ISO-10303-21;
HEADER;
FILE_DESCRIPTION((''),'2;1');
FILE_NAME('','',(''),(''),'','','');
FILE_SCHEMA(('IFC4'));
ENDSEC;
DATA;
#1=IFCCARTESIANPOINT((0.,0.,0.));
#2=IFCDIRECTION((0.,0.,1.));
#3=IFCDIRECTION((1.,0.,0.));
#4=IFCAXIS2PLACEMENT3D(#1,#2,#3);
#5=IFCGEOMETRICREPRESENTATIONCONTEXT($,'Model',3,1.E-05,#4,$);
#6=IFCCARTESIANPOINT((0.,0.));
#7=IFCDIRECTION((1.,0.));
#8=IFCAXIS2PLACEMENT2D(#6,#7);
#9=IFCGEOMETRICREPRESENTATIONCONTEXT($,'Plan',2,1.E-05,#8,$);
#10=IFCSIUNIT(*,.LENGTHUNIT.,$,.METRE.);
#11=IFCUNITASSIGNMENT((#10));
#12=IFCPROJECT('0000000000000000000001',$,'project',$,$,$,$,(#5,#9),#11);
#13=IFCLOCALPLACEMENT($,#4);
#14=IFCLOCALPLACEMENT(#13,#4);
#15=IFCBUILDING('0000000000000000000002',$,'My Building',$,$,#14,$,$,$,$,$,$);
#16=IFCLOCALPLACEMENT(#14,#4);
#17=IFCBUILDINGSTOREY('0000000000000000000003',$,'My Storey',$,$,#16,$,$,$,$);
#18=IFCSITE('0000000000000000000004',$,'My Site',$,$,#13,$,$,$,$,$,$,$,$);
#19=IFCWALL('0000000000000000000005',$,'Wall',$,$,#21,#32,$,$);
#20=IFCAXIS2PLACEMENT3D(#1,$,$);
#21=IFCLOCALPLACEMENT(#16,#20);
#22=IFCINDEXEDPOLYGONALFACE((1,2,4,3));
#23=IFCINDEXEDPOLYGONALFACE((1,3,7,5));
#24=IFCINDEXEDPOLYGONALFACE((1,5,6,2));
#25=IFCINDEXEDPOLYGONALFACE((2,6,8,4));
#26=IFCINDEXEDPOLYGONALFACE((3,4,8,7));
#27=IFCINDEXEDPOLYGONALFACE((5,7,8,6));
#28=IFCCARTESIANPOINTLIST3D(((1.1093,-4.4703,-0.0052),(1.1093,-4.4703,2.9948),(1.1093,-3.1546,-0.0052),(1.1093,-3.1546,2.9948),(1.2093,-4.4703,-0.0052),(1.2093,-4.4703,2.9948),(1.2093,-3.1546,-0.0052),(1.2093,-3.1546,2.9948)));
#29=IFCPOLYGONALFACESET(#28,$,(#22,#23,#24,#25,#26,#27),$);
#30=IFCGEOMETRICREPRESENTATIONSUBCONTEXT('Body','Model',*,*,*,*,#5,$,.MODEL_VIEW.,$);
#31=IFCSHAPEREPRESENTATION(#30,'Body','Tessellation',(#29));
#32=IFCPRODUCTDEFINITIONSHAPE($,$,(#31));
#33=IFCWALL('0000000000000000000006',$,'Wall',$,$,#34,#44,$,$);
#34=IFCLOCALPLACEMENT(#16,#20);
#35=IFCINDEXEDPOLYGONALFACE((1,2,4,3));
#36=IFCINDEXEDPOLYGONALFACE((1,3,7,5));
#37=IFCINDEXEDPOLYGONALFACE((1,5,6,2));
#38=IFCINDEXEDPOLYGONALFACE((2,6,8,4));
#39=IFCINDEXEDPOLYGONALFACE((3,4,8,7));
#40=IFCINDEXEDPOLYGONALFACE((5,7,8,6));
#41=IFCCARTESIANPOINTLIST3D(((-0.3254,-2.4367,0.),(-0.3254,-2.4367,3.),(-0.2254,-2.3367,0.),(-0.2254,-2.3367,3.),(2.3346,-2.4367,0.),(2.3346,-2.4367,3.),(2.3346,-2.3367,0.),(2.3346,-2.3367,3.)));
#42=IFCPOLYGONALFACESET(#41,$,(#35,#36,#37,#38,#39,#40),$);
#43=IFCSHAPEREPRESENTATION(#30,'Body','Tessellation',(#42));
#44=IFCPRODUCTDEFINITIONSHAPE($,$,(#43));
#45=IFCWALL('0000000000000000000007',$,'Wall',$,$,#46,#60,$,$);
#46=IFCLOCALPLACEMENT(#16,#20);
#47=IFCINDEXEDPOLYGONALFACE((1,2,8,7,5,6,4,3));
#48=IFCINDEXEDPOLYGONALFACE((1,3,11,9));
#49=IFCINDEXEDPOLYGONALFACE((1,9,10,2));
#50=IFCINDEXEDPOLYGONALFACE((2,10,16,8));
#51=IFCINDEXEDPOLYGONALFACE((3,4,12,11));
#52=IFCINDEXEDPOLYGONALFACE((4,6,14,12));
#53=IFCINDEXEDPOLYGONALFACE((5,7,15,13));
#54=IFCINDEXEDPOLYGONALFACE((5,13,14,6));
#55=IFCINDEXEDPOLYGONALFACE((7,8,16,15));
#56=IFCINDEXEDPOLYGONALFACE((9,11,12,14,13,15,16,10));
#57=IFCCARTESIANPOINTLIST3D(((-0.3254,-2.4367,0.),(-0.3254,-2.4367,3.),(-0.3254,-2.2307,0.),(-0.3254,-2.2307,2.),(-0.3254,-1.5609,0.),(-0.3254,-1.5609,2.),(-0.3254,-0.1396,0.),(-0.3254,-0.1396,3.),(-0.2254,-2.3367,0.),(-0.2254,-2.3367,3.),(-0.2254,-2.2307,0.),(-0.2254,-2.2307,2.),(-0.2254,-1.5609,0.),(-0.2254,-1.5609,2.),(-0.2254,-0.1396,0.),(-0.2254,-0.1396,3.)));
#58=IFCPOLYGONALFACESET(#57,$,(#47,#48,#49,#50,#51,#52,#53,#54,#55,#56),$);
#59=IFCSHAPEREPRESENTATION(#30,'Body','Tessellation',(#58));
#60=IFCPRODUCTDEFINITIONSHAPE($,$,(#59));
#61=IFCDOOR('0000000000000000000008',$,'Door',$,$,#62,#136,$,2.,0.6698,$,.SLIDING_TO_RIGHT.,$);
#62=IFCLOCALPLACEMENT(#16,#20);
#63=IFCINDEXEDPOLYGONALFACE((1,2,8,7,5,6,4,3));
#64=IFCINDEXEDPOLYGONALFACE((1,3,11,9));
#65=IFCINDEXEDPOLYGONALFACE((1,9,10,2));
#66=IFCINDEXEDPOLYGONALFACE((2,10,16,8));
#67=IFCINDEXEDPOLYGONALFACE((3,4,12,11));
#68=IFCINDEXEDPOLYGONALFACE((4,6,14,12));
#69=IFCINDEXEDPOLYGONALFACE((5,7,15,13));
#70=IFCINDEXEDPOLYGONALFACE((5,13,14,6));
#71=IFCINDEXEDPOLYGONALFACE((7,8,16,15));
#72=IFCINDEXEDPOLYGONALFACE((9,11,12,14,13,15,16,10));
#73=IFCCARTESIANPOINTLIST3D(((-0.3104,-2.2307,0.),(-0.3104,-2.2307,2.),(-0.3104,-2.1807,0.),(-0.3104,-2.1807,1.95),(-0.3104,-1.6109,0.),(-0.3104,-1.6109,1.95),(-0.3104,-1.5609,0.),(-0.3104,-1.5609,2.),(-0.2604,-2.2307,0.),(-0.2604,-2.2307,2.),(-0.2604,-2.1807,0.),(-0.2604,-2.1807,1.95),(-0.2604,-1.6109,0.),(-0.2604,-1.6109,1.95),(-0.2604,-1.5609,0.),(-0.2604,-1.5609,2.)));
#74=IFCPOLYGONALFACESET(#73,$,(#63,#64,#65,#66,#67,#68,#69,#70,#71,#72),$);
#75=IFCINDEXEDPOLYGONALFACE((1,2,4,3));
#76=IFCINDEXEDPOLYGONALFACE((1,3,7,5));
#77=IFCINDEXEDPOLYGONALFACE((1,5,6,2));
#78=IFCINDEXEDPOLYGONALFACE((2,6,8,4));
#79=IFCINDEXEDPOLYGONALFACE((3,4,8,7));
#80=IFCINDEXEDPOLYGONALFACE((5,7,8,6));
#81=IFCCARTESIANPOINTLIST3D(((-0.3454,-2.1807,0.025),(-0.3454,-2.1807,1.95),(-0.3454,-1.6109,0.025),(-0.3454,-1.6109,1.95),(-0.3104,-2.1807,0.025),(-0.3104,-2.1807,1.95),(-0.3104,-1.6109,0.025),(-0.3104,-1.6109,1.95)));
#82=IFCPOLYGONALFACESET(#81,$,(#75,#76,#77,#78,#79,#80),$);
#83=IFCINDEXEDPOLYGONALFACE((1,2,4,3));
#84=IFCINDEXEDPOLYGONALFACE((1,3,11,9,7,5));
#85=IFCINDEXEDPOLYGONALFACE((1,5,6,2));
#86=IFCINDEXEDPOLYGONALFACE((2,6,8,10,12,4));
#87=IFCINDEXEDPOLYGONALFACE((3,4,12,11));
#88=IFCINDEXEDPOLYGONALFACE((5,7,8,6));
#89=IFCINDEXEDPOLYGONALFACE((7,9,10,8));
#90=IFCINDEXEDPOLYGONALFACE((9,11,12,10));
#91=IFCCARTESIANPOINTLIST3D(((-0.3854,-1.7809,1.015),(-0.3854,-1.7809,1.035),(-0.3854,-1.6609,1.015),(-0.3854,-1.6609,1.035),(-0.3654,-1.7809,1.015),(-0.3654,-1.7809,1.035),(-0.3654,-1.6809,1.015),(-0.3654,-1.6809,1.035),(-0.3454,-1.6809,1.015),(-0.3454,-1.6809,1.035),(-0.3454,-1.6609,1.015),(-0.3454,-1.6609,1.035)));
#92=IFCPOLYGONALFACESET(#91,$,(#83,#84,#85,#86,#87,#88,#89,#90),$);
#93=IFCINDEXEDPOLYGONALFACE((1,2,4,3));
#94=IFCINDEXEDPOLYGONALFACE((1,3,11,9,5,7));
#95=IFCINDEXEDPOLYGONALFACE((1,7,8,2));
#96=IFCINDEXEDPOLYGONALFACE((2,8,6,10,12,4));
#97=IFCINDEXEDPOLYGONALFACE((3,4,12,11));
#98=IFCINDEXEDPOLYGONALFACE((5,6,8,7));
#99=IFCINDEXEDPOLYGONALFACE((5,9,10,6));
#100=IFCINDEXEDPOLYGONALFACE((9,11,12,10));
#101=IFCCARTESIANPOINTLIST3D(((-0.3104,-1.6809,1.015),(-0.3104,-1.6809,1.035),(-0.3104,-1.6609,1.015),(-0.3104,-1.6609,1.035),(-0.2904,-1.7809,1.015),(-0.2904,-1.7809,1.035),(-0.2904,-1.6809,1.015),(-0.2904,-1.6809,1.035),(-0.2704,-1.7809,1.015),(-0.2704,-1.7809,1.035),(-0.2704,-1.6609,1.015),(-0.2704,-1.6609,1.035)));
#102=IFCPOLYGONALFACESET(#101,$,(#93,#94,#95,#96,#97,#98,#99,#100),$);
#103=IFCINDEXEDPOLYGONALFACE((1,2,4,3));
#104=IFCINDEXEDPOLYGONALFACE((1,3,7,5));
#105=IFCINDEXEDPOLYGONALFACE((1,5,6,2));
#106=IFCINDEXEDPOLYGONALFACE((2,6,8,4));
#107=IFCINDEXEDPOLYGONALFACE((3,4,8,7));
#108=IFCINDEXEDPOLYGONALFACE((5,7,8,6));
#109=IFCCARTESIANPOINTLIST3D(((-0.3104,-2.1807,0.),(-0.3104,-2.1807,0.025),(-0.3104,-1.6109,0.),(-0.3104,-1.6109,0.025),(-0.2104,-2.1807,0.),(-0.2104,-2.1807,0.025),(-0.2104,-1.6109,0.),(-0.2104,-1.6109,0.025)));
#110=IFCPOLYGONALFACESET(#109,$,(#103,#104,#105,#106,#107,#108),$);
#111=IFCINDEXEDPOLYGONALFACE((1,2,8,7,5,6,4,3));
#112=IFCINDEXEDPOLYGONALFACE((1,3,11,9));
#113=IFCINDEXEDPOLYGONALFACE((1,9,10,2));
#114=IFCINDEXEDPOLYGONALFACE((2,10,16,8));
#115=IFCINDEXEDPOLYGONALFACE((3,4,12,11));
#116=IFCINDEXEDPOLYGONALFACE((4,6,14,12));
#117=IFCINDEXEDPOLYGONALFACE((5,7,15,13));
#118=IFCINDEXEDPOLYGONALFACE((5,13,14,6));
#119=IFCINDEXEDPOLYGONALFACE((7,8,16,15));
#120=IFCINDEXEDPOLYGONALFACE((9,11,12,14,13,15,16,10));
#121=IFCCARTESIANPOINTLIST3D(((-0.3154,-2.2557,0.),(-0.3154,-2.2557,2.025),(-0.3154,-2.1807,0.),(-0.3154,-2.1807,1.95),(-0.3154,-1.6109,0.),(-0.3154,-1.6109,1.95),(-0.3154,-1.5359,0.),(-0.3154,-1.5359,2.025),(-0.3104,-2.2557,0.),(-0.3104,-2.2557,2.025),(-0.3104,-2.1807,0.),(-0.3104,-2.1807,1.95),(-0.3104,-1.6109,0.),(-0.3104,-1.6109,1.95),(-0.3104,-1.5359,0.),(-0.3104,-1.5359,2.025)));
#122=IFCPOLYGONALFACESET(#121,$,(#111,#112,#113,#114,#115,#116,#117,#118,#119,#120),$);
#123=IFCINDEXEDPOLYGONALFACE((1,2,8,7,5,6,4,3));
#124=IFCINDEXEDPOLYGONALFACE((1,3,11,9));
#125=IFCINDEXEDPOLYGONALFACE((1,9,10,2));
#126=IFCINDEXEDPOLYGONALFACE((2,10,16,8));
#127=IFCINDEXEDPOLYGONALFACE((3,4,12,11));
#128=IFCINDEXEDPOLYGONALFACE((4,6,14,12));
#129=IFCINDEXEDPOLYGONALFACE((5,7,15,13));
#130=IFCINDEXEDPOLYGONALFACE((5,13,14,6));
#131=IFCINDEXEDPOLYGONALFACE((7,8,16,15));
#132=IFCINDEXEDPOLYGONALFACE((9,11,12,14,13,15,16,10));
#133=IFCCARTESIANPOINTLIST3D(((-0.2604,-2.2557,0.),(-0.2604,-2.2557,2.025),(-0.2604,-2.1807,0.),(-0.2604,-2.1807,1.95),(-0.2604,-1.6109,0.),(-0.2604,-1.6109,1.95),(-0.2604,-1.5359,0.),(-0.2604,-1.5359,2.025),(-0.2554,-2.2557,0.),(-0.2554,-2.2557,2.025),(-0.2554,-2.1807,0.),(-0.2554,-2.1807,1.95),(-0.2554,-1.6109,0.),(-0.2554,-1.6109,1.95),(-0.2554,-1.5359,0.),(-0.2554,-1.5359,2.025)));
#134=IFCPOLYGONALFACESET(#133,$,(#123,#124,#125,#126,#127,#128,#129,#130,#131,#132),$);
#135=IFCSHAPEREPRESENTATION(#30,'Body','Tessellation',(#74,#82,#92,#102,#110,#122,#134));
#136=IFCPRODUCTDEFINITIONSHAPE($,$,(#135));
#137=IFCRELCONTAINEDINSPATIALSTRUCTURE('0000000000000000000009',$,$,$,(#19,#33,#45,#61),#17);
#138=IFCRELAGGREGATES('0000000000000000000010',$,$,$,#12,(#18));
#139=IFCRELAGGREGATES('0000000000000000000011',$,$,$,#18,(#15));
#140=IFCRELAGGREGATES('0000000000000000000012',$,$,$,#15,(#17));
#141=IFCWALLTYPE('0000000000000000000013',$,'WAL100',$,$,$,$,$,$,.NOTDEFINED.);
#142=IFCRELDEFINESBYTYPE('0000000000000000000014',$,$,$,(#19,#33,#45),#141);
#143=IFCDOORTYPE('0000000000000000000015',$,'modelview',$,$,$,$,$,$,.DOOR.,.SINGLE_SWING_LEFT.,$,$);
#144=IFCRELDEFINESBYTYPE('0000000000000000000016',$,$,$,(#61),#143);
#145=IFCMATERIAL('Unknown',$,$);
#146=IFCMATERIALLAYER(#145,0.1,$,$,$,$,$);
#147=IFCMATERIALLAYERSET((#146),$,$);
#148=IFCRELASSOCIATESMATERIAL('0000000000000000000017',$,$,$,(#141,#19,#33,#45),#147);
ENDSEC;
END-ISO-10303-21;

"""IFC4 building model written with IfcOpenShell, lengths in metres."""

from ifc_helpers import new_model, entity, si_unit, frame, origin_with_axes, origin_2d_with_axis, place, context, subcontext, project, spatial, line, indexed_curve, outline, extrude, shape, source, transform, mapped, material, layer, layer_set, layer_usage, type_object, type_shapes, element, fill, save


model = new_model("IFC4")

# Units and contexts
model_context = context("Model", 3, precision=1e-05, world=origin_with_axes())
plan_context = context("Plan", 2, precision=1e-05, world=origin_2d_with_axis())
body_context_1 = subcontext(model_context, "Body", "Model", "MODEL_VIEW")
body_context_2 = subcontext(plan_context, "Body", "Plan", "PLAN_VIEW")
ifc_project = project(units=[si_unit("LENGTHUNIT", "METRE")], contexts=[model_context, plan_context])

# Site, building, storey
site_placement = place(None, origin_with_axes())
site = spatial("IfcSite", under=ifc_project, at=site_placement, Name="My Site")
building_placement = place(site_placement, origin_with_axes())
building = spatial("IfcBuilding", under=site, at=building_placement, Name="My Building")
storey_placement = place(building_placement, origin_with_axes())
storey = spatial("IfcBuildingStorey", under=building, at=storey_placement, Name="My Storey")

# Walls
ifc_material = material(Name="Unknown")
ifc_layer_1 = layer(ifc_material, 0.1)
ifc_layer_set_1 = layer_set([ifc_layer_1])
ifc_layer_usage_1 = layer_usage(ifc_layer_set_1, "AXIS2", "POSITIVE", 0.0)
wall_type_1 = type_object("IfcWallType", Name="WAL100", PredefinedType="NOTDEFINED", material=ifc_layer_set_1)
wall_1_placement = place(storey_placement, frame((1.2093, -4.4703, -0.0052), z_axis=(0.0, 0.0, 1.0), x_axis=(0.0, 1.0, 0.0)))
element("IfcWall", 1, at=wall_1_placement, inside=storey, type_object=wall_type_1, material=ifc_layer_usage_1, Name="Wall", context=body_context_1, shape_type="SweptSolid", body=[
    extrude(outline(indexed_curve([(0.0, 0.0), (0.0, 0.1), (1.3157, 0.1), (1.3157, 0.0)], segments=[line(1, 2, 3, 4, 1)])), origin_with_axes(), (0.0, 0.0, 1.0), 3.0),
])
ifc_layer_usage_2 = layer_usage(ifc_layer_set_1, "AXIS2", "POSITIVE", 0.0)
wall_2_placement = place(storey_placement, frame((2.3346, -2.3367, 0.0), z_axis=(0.0, 0.0, 1.0), x_axis=(-1.0, 0.0, 0.0)))
element("IfcWall", 2, at=wall_2_placement, inside=storey, type_object=wall_type_1, material=ifc_layer_usage_2, Name="Wall", context=body_context_1, shape_type="SweptSolid", body=[
    extrude(outline(indexed_curve([(0.0, 0.0), (0.0, 0.1), (2.66, 0.1), (2.56, 0.0)], segments=[line(1, 2, 3, 4, 1)])), origin_with_axes(), (0.0, 0.0, 1.0), 3.0),
])

# Wall, opening, door
ifc_layer_usage_3 = layer_usage(ifc_layer_set_1, "AXIS2", "POSITIVE", 0.0)
wall_3_placement = place(storey_placement, frame((-0.2254, -2.3367, 0.0), z_axis=(0.0, 0.0, 1.0), x_axis=(0.0, 1.0, 0.0)))
wall_3 = element("IfcWall", 3, at=wall_3_placement, inside=storey, type_object=wall_type_1, material=ifc_layer_usage_3, Name="Wall", context=body_context_1, shape_type="SweptSolid", body=[
    extrude(outline(indexed_curve([(0.0, 0.0), (-0.1, 0.1), (2.197, 0.1), (2.197, 0.0)], segments=[line(1, 2, 3, 4, 1)])), origin_with_axes(), (0.0, 0.0, 1.0), 3.0),
])
shared_shape_1 = source(origin_with_axes(), body_context_1, "Body", "SweptSolid", [
    extrude(outline(indexed_curve([(0.0, 0.0), (0.6698, 0.0), (0.6698, 2.0), (0.0, 2.0)], segments=[line(1, 2, 3, 4, 1)])), frame((0.0, -0.6, 0.0), z_axis=(0.0, -1.0, 0.0), x_axis=(1.0, 0.0, 0.0)), (0.0, 0.0, -1.0), 1.2),
])
opening_1_placement = place(wall_3_placement, frame((0.7758, 0.085, 0.0), z_axis=(0.0, 0.0, 1.0), x_axis=(-1.0, 0.0, 0.0)))
opening_1 = element("IfcOpeningElement", 4, at=opening_1_placement, cuts=wall_3, PredefinedType="OPENING", context=body_context_1, shape_type="MappedRepresentation", body=[
    mapped(shared_shape_1, transform((0.0, 0.0, 0.0), x_axis=(1.0, 0.0, 0.0), y_axis=(0.0, 1.0, 0.0), z_axis=(0.0, 0.0, 1.0), scale=1.0)),
])
door_type_1 = type_object("IfcDoorType", Name="modelview", OperationType="SINGLE_SWING_LEFT", PredefinedType="DOOR")
shared_shape_2 = source(origin_with_axes(), body_context_1, "Body", "SweptSolid", [
    extrude(outline(indexed_curve([(0.0, 0.0), (0.0, 2.0), (0.6698, 2.0), (0.6698, 0.0), (0.6198, 0.0), (0.6198, 1.95), (0.05, 1.95), (0.05, 0.0)], segments=[line(1, 2, 3, 4, 5, 6, 7, 8, 1)])), frame((0.0, 0.0, 0.0), z_axis=(0.0, -1.0, 0.0), x_axis=(1.0, 0.0, 0.0)), (0.0, 0.0, -1.0), 0.05),
    extrude(outline(indexed_curve([(0.0, 0.0), (0.5698, 0.0), (0.5698, 0.035), (0.0, 0.035)], segments=[line(1, 2, 3, 4, 1)])), frame((0.05, -0.035, 0.025), z_axis=(0.0, 0.0, 1.0), x_axis=(1.0, 0.0, 0.0)), (0.0, 0.0, 1.0), 1.925),
    extrude(outline(indexed_curve([(0.0, 0.0), (0.0, -0.04), (0.12, -0.04), (0.12, -0.02), (0.02, -0.02), (0.02, 0.0)], segments=[line(1, 2, 3, 4, 5, 6, 1)])), frame((0.1, -0.035, 1.015), z_axis=(0.0, 0.0, 1.0), x_axis=(1.0, 0.0, 0.0)), (0.0, 0.0, 1.0), 0.02),
    extrude(outline(indexed_curve([(0.0, 0.0), (0.0, 0.04), (0.12, 0.04), (0.12, 0.02), (0.02, 0.02), (0.02, 0.0)], segments=[line(1, 2, 3, 4, 5, 6, 1)])), frame((0.1, 0.0, 1.015), z_axis=(0.0, 0.0, 1.0), x_axis=(1.0, 0.0, 0.0)), (0.0, 0.0, 1.0), 0.02),
    extrude(outline(indexed_curve([(0.0, 0.0), (0.5698, 0.0), (0.5698, 0.1), (0.0, 0.1)], segments=[line(1, 2, 3, 4, 1)])), frame((0.05, 0.0, 0.0), z_axis=(0.0, 0.0, 1.0), x_axis=(1.0, 0.0, 0.0)), (0.0, 0.0, 1.0), 0.025),
    extrude(outline(indexed_curve([(0.0, 0.0), (0.0, 2.025), (0.7198, 2.025), (0.7198, 0.0), (0.6448, 0.0), (0.6448, 1.95), (0.075, 1.95), (0.075, 0.0)], segments=[line(1, 2, 3, 4, 5, 6, 7, 8, 1)])), frame((-0.025, -0.005, 0.0), z_axis=(0.0, -1.0, 0.0), x_axis=(1.0, 0.0, 0.0)), (0.0, 0.0, -1.0), 0.005),
    extrude(outline(indexed_curve([(0.0, 0.0), (0.0, 2.025), (0.7198, 2.025), (0.7198, 0.0), (0.6448, 0.0), (0.6448, 1.95), (0.075, 1.95), (0.075, 0.0)], segments=[line(1, 2, 3, 4, 5, 6, 7, 8, 1)])), frame((-0.025, 0.05, 0.0), z_axis=(0.0, -1.0, 0.0), x_axis=(1.0, 0.0, 0.0)), (0.0, 0.0, -1.0), 0.005),
])
shared_shape_3 = source(origin_with_axes(), body_context_2, "Body", "Curve2D", [
    entity("IfcIndexedPolyCurve", entity("IfcCartesianPointList2D", [[0.0, 0.0], [0.05, 0.0], [0.05, 0.05], [0.0, 0.05]]), [entity("IfcLineIndex", [1, 2, 3, 4, 1])]),
    entity("IfcIndexedPolyCurve", entity("IfcCartesianPointList2D", [[0.6698, 0.0], [0.6198, 0.0], [0.6198, 0.05], [0.6698, 0.05]]), [entity("IfcLineIndex", [1, 2, 3, 4, 1])]),
    entity("IfcIndexedPolyCurve", entity("IfcCartesianPointList2D", [[0.9047, -0.035], [0.3349, -0.035], [0.3349, 0.0], [0.9047, 0.0]]), [entity("IfcLineIndex", [1, 2, 3, 4, 1])]),
])
type_shapes(door_type_1, [shared_shape_2, shared_shape_3])
door_1_placement = place(opening_1_placement, frame((0.0, 0.0, 0.0), z_axis=(0.0, 0.0, 1.0), x_axis=(1.0, 0.0, 0.0)))
door_1 = element("IfcDoor", 5, at=door_1_placement, inside=storey, type_object=door_type_1, Name="Door", OperationType="SLIDING_TO_RIGHT", OverallHeight=2.0, OverallWidth=0.6698, shapes=[
    shape(body_context_1, "Body", "MappedRepresentation", [mapped(shared_shape_2, transform((0.0, 0.0, 0.0), x_axis=(1.0, 0.0, 0.0), y_axis=(0.0, 1.0, 0.0), z_axis=(0.0, 0.0, 1.0), scale=1.0))]),
    shape(body_context_2, "Body", "MappedRepresentation", [mapped(shared_shape_3, transform((0.0, 0.0, 0.0), x_axis=(1.0, 0.0, 0.0), y_axis=(0.0, 1.0, 0.0), z_axis=(0.0, 0.0, 1.0), scale=1.0))]),
])
fill(opening_1, door_1)

save(model, "model.ifc")
